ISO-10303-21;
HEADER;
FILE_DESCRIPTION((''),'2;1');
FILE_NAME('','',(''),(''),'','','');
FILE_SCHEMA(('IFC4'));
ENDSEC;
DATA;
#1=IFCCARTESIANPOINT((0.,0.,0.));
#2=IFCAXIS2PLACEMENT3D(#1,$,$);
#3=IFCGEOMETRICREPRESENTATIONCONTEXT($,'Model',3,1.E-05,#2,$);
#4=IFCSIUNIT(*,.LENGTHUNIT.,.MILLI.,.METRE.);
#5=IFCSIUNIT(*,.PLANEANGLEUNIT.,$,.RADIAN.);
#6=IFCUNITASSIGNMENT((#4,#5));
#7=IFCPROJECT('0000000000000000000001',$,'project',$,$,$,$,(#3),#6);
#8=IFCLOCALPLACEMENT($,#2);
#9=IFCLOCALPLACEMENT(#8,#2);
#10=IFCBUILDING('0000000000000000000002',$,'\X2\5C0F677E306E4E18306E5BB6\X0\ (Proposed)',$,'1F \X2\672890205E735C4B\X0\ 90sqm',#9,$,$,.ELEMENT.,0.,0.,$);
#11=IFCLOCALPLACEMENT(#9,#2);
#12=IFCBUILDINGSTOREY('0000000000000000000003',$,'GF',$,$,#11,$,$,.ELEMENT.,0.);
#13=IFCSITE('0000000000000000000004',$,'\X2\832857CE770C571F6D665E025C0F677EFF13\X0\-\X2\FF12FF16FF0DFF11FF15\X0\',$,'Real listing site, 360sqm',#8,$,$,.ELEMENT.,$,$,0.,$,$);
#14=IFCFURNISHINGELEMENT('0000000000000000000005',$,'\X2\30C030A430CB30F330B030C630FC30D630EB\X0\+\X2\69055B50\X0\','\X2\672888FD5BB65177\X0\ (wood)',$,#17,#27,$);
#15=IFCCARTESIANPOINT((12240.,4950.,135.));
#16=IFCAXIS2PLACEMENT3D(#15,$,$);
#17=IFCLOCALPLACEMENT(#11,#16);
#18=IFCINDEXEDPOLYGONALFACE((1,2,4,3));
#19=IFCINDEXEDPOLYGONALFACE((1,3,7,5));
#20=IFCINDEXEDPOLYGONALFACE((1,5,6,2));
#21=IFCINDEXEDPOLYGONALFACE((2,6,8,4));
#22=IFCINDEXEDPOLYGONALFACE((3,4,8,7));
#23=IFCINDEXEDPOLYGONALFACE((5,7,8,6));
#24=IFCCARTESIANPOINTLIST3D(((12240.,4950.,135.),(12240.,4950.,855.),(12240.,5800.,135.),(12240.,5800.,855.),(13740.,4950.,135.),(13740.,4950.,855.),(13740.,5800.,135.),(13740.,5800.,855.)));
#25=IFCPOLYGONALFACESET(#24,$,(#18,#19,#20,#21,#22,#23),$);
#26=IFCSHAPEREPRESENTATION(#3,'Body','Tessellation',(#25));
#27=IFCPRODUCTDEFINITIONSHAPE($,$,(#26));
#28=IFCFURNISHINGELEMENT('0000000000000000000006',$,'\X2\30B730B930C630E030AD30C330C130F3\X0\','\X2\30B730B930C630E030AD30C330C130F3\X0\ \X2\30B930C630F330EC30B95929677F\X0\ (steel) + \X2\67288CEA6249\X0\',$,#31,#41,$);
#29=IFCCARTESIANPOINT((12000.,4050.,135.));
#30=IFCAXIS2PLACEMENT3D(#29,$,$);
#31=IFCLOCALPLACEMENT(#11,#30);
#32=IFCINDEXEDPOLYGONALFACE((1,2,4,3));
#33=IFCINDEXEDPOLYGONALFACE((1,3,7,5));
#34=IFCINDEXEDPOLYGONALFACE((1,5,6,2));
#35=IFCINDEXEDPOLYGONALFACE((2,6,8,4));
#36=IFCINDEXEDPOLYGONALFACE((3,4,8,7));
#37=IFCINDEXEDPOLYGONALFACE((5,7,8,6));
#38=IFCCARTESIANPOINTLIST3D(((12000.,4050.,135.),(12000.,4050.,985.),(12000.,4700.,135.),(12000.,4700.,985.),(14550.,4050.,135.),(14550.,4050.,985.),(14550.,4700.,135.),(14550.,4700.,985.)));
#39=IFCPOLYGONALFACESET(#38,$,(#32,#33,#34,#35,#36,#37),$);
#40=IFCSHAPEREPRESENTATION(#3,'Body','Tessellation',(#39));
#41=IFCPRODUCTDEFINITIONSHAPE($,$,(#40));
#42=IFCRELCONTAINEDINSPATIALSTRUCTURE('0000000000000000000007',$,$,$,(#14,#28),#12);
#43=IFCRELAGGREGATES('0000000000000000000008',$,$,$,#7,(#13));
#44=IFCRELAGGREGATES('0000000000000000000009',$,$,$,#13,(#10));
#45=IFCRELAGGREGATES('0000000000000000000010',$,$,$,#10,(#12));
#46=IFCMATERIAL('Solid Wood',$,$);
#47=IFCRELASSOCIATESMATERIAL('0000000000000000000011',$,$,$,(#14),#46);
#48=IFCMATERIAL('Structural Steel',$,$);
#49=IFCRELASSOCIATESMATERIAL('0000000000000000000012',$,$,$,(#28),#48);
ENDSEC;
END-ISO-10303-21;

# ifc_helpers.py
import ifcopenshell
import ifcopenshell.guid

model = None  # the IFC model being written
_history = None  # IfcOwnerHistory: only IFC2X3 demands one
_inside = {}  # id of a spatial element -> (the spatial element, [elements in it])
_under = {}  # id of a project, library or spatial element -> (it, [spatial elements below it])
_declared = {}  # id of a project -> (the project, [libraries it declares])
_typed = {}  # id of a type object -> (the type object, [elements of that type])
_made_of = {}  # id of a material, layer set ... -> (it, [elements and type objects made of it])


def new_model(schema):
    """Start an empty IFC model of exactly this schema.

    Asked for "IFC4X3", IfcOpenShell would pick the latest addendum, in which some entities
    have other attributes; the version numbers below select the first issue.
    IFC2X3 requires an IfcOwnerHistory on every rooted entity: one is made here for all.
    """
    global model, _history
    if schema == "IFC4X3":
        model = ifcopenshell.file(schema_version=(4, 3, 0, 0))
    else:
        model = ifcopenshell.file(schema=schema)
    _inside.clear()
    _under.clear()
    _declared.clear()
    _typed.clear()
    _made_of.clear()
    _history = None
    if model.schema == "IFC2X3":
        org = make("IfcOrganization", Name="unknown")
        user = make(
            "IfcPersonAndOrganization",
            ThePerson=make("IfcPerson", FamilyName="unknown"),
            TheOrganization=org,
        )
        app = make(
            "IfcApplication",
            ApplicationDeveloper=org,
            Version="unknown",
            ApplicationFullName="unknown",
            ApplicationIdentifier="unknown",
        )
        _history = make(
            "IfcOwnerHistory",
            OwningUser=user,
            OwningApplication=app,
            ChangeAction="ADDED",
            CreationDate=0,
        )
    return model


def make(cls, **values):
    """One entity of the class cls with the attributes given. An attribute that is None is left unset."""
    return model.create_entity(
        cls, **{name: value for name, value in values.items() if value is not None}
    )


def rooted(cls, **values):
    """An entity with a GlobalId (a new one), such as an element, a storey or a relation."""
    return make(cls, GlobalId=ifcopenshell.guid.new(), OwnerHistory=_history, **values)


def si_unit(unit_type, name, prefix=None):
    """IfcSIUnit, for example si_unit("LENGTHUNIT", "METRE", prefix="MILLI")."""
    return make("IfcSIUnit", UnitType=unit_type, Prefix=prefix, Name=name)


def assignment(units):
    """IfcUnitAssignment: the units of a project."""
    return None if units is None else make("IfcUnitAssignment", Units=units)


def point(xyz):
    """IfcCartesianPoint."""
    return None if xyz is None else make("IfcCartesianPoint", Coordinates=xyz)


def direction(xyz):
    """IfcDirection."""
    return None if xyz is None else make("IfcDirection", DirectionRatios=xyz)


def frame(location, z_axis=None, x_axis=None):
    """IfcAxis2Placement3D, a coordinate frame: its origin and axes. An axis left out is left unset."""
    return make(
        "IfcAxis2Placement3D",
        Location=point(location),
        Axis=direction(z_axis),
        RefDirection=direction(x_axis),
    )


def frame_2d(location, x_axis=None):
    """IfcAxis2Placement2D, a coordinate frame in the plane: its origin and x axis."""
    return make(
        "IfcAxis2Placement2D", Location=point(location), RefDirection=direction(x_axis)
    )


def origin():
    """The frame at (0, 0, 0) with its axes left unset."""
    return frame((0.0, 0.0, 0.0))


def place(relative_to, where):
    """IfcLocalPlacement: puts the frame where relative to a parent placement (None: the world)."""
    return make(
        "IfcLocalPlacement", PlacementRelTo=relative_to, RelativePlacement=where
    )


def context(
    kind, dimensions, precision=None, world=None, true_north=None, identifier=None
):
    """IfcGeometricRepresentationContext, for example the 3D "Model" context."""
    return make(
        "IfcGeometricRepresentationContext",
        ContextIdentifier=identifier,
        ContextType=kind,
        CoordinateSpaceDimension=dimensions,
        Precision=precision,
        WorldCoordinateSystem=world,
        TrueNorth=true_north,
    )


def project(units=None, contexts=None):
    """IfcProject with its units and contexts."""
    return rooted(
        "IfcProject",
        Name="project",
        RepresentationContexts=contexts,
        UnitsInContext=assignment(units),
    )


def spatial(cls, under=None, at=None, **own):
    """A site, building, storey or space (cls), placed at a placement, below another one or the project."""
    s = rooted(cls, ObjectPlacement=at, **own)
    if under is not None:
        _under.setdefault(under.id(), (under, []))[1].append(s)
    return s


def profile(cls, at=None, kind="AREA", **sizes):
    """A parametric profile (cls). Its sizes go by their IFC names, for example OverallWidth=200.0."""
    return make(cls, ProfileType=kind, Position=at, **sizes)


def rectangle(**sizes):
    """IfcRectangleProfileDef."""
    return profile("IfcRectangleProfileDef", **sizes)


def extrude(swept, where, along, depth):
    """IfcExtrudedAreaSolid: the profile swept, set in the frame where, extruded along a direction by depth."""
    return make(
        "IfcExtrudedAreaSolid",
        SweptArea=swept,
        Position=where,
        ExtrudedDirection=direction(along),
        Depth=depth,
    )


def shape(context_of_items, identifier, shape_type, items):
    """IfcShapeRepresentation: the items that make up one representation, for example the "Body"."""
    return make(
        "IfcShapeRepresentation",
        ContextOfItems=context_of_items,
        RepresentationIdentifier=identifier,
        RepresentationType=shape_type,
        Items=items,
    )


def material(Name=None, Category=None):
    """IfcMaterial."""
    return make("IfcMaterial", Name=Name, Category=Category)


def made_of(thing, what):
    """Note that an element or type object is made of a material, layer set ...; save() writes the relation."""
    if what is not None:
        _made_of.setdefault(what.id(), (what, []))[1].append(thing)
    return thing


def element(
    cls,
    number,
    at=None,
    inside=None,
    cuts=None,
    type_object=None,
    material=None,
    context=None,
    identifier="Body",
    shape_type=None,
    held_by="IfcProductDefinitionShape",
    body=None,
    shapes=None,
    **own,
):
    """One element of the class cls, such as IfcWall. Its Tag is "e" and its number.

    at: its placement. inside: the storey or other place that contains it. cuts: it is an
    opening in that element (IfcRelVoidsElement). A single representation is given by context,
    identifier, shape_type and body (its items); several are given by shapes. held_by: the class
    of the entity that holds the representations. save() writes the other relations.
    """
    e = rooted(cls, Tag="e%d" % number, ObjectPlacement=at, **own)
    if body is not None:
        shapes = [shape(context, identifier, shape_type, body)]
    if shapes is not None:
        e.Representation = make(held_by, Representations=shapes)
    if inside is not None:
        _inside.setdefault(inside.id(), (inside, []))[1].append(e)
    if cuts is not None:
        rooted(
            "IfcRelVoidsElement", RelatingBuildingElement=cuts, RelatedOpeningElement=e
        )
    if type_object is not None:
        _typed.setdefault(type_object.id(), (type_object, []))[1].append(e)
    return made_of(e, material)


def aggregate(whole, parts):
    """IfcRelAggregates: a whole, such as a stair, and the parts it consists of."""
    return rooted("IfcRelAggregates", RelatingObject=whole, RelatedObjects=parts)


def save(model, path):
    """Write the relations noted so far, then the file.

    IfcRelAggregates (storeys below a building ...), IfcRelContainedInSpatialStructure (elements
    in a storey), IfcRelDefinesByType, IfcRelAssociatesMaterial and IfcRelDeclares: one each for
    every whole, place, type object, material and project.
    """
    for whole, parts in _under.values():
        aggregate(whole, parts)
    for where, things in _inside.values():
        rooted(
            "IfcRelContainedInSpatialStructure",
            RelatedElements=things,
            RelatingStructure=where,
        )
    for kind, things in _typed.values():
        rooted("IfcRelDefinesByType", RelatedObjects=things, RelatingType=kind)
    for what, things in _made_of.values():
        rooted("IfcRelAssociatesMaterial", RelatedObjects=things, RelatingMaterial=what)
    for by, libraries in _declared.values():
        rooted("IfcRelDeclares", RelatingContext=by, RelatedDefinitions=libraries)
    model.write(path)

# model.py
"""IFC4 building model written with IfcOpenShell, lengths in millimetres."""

from ifc_helpers import new_model, si_unit, frame, frame_2d, origin, place, context, project, spatial, rectangle, extrude, material, element, save


model = new_model("IFC4")

# Units and contexts
model_context = context("Model", 3, precision=1e-05, world=origin())
ifc_project = project(units=[si_unit("LENGTHUNIT", "METRE", prefix="MILLI"), si_unit("PLANEANGLEUNIT", "RADIAN")], contexts=[model_context])

# Site, building, storey
site_placement = place(None, origin())
site = spatial("IfcSite", under=ifc_project, at=site_placement, Name="茨城県土浦市小松３-２６－１５", ObjectType="Real listing site, 360sqm", CompositionType="ELEMENT", RefElevation=0.0)
building_placement = place(site_placement, origin())
building = spatial("IfcBuilding", under=site, at=building_placement, Name="小松の丘の家 (Proposed)", ObjectType="1F 木造平屋 90sqm", CompositionType="ELEMENT", ElevationOfRefHeight=0.0, ElevationOfTerrain=0.0)
storey_placement = place(building_placement, origin())
storey = spatial("IfcBuildingStorey", under=building, at=storey_placement, Name="GF", CompositionType="ELEMENT", Elevation=0.0)

# Shared definitions
ifc_material_1 = material(Name="Solid Wood")

# Shared definitions
ifc_material_2 = material(Name="Structural Steel")

# Furnishing elements
furnishing_1_placement = place(storey_placement, frame((12240.0, 4950.0, 135.0)))
element("IfcFurnishingElement", 1, at=furnishing_1_placement, inside=storey, material=ifc_material_1, Name="ダイニングテーブル+椅子", Description="木製家具 (wood)", context=model_context, shape_type="SweptSolid", body=[
    extrude(rectangle(XDim=1500.0, YDim=850.0, at=frame_2d((750.0, 425.0))), frame((12240.0, 4950.0, 135.0)), (0.0, 0.0, 1.0), 720.0),
])
furnishing_2_placement = place(storey_placement, frame((12000.0, 4050.0, 135.0)))
element("IfcFurnishingElement", 2, at=furnishing_2_placement, inside=storey, material=ifc_material_2, Name="システムキッチン", Description="システムキッチン ステンレス天板 (steel) + 木質扉", context=model_context, shape_type="SweptSolid", body=[
    extrude(rectangle(XDim=2550.0, YDim=650.0, at=frame_2d((1275.0, 325.0))), frame((12000.0, 4050.0, 135.0)), (0.0, 0.0, 1.0), 850.0),
])

save(model, "model.ifc")
